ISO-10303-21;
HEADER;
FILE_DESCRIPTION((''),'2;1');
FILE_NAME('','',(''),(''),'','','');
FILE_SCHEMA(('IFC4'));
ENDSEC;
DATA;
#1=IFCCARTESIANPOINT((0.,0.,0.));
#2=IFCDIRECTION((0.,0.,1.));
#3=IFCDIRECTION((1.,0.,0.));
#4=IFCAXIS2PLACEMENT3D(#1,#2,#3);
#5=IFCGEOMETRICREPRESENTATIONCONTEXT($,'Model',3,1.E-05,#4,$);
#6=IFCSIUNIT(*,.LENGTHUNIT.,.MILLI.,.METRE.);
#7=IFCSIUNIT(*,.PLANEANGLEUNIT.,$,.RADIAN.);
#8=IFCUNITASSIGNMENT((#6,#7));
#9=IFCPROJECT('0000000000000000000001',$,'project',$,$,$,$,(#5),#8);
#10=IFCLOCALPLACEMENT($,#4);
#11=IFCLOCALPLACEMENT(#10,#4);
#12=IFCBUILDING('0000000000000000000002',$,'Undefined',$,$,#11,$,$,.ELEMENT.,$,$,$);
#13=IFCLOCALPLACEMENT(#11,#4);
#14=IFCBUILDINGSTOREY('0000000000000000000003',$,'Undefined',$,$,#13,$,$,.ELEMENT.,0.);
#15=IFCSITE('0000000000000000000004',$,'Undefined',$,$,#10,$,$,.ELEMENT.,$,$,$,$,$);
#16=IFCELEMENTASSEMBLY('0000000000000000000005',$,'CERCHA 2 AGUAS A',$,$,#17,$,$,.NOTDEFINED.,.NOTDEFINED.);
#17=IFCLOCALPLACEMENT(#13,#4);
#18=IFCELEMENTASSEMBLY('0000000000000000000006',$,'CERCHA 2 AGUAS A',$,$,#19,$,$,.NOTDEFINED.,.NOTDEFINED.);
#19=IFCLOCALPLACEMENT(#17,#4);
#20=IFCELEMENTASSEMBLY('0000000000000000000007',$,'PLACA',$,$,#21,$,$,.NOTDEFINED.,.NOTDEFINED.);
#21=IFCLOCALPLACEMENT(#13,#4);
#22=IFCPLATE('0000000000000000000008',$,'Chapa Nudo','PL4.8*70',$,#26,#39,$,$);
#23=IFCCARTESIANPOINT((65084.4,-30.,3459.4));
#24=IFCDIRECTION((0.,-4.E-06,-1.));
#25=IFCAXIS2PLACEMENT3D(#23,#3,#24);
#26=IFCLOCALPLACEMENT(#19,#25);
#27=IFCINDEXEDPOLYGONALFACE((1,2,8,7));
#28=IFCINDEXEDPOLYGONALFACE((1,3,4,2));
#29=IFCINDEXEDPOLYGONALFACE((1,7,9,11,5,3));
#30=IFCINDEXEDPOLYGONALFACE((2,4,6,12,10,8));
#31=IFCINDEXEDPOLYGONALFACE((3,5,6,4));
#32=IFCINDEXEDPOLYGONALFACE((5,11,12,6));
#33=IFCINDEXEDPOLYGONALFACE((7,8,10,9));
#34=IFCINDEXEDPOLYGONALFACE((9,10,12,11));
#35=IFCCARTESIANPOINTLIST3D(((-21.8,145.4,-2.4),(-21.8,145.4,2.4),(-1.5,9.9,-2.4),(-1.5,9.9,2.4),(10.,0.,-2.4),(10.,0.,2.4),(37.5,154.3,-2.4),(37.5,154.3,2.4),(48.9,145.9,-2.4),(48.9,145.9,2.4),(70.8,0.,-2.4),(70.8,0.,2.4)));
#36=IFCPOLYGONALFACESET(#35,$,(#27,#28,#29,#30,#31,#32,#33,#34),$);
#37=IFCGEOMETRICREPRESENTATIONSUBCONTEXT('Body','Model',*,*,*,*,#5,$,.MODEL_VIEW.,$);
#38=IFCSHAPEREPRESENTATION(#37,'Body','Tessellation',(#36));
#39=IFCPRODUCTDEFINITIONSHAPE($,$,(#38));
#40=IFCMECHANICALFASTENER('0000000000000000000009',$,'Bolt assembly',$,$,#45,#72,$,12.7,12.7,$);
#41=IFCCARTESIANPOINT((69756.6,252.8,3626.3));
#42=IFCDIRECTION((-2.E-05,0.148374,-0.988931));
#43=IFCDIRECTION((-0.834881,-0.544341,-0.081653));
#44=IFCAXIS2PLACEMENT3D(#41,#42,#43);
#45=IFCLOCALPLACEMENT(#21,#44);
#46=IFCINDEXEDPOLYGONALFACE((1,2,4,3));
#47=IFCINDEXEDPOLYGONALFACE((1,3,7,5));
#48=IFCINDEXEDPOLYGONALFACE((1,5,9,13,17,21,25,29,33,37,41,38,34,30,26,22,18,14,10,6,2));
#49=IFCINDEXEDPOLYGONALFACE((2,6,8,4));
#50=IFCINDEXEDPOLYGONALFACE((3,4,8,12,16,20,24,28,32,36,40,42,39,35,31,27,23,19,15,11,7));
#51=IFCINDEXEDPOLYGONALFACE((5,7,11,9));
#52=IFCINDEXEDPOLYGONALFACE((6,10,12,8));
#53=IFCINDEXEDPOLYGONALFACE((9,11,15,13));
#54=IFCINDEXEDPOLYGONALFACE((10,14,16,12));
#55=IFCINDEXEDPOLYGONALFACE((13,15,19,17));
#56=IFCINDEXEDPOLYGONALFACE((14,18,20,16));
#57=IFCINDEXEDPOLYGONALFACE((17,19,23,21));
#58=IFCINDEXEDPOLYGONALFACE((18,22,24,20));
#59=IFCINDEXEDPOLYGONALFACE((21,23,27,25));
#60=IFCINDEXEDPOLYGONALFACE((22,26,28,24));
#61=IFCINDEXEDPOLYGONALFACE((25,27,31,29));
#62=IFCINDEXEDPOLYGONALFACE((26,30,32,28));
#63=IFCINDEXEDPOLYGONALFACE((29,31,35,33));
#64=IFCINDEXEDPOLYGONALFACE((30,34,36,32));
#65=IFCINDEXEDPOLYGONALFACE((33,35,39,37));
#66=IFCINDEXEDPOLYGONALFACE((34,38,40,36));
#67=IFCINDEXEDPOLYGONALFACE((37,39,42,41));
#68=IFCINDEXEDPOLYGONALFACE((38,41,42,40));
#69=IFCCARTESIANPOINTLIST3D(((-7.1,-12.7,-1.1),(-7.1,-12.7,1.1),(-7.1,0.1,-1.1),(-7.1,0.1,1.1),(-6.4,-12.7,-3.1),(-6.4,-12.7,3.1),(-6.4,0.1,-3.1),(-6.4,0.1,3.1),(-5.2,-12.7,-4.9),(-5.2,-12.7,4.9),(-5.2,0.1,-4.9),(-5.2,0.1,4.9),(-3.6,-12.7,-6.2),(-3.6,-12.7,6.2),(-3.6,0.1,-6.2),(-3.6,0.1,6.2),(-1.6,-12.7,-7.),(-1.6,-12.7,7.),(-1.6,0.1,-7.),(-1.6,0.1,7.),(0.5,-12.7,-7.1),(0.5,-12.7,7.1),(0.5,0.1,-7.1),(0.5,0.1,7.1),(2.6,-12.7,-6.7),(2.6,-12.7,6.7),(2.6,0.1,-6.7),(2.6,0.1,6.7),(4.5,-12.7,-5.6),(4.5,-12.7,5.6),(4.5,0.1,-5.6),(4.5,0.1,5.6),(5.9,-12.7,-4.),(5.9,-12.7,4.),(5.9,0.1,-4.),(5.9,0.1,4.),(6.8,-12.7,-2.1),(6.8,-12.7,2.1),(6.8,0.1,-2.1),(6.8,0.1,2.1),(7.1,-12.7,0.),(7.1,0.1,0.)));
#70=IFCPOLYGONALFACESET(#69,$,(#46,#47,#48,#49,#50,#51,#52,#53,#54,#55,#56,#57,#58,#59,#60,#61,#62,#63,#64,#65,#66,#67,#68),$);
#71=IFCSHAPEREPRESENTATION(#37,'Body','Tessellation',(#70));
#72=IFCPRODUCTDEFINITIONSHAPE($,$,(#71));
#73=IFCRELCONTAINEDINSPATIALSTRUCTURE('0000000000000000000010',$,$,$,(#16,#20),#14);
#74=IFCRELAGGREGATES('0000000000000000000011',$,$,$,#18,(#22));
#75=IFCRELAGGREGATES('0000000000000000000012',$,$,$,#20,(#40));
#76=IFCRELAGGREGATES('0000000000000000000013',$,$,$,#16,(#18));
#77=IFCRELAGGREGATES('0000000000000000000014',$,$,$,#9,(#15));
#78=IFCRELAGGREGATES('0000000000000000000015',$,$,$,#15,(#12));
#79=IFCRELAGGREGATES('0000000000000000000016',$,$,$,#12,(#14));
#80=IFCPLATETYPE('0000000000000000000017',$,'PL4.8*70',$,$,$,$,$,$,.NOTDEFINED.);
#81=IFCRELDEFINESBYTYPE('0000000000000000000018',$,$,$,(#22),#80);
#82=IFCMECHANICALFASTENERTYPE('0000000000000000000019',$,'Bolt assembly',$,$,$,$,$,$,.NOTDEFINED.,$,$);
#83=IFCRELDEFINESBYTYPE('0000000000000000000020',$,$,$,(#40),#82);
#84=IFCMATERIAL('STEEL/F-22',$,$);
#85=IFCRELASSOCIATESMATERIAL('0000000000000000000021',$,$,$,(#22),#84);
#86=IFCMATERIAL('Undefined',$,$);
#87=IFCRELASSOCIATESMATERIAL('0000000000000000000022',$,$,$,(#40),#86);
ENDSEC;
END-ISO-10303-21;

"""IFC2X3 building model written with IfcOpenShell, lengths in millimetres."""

from ifc_helpers import new_model, si_unit, frame, origin_with_axes, origin_2d_with_axis, place, context, subcontext, project, spatial, polyline, circle, outline, extrude, source, transform, mapped, material, type_object, element, aggregate, save


model = new_model("IFC2X3")

# Units and contexts
model_context = context("Model", 3, precision=1e-05, world=origin_with_axes())
body_context = subcontext(model_context, "Body", "Model", "MODEL_VIEW")
ifc_project = project(units=[si_unit("LENGTHUNIT", "METRE", prefix="MILLI"), si_unit("PLANEANGLEUNIT", "RADIAN")], contexts=[model_context])

# Site, building, storey
site_placement = place(None, origin_with_axes())
site = spatial("IfcSite", under=ifc_project, at=site_placement, Name="Undefined", CompositionType="ELEMENT")
building_placement = place(site_placement, origin_with_axes())
building = spatial("IfcBuilding", under=site, at=building_placement, Name="Undefined", CompositionType="ELEMENT")
storey_placement = place(building_placement, origin_with_axes())
storey = spatial("IfcBuildingStorey", under=building, at=storey_placement, Name="Undefined", CompositionType="ELEMENT", Elevation=0.0)

# Element assemblies
assembly_1_placement = place(storey_placement, origin_with_axes())
assembly_1 = element("IfcElementAssembly", 1, at=assembly_1_placement, inside=storey, Name="CERCHA 2 AGUAS A", AssemblyPlace="NOTDEFINED", PredefinedType="NOTDEFINED")
assembly_2_placement = place(assembly_1_placement, origin_with_axes())
assembly_2 = element("IfcElementAssembly", 2, at=assembly_2_placement, Name="CERCHA 2 AGUAS A", AssemblyPlace="NOTDEFINED", PredefinedType="NOTDEFINED")
ifc_material_1 = material(Name="STEEL/F-22")

# Element assembly
assembly_3_placement = place(storey_placement, origin_with_axes())
assembly_3 = element("IfcElementAssembly", 3, at=assembly_3_placement, inside=storey, Name="PLACA", AssemblyPlace="NOTDEFINED", PredefinedType="NOTDEFINED")

# Plate
plate_type_1 = type_object("IfcPlateType", Name="PL4.8*70", PredefinedType="NOTDEFINED")
plate_1_placement = place(assembly_2_placement, frame((65084.4, -30.0, 3459.4), z_axis=(1.0, 0.0, 0.0), x_axis=(0.0, -0.000004, -1.0)))
plate_1 = element("IfcPlate", 4, at=plate_1_placement, type_object=plate_type_1, material=ifc_material_1, Name="Chapa Nudo", Description="PL4.8*70", context=body_context, shape_type="SweptSolid", body=[
    extrude(outline(polyline([(-1.5, 9.9), (10.0, 0.0), (70.8, 0.0), (70.8, 0.0), (48.9, 145.9), (37.5, 154.3), (-21.8, 145.4), (-1.5, 9.9)])), frame((0.0, 0.0, -2.4), z_axis=(0.0, 0.0, 1.0), x_axis=(1.0, 0.0, 0.0)), (0.0, 0.0, 1.0), 4.8),
])
aggregate(assembly_2, [plate_1])

# Mechanical fastener
ifc_material_2 = material(Name="Undefined")
mechanical_fastener_type = type_object("IfcMechanicalFastenerType", Name="Bolt assembly")
shared_shape_1 = source(origin_with_axes(), body_context, "Body", "SweptSolid", [
    extrude(circle(Radius=7.1, at=origin_2d_with_axis()), frame((0.0, -12.7, 0.0), z_axis=(0.0, 1.0, 0.0), x_axis=(1.0, 0.0, 0.0)), (0.0, 0.0, 1.0), 12.8),
])
mechanical_fastener_1_placement = place(assembly_3_placement, frame((69756.6, 252.8, 3626.3), z_axis=(-0.00002, 0.148374, -0.988931), x_axis=(-0.834881, -0.544341, -0.081653)))
mechanical_fastener_1 = element("IfcMechanicalFastener", 5, at=mechanical_fastener_1_placement, type_object=mechanical_fastener_type, material=ifc_material_2, Name="Bolt assembly", NominalDiameter=12.7, NominalLength=12.7, context=body_context, shape_type="MappedRepresentation", body=[
    mapped(shared_shape_1, transform((0.0, 0.0, 0.0))),
])
aggregate(assembly_3, [mechanical_fastener_1])

aggregate(assembly_1, [assembly_2])

save(model, "model.ifc")
